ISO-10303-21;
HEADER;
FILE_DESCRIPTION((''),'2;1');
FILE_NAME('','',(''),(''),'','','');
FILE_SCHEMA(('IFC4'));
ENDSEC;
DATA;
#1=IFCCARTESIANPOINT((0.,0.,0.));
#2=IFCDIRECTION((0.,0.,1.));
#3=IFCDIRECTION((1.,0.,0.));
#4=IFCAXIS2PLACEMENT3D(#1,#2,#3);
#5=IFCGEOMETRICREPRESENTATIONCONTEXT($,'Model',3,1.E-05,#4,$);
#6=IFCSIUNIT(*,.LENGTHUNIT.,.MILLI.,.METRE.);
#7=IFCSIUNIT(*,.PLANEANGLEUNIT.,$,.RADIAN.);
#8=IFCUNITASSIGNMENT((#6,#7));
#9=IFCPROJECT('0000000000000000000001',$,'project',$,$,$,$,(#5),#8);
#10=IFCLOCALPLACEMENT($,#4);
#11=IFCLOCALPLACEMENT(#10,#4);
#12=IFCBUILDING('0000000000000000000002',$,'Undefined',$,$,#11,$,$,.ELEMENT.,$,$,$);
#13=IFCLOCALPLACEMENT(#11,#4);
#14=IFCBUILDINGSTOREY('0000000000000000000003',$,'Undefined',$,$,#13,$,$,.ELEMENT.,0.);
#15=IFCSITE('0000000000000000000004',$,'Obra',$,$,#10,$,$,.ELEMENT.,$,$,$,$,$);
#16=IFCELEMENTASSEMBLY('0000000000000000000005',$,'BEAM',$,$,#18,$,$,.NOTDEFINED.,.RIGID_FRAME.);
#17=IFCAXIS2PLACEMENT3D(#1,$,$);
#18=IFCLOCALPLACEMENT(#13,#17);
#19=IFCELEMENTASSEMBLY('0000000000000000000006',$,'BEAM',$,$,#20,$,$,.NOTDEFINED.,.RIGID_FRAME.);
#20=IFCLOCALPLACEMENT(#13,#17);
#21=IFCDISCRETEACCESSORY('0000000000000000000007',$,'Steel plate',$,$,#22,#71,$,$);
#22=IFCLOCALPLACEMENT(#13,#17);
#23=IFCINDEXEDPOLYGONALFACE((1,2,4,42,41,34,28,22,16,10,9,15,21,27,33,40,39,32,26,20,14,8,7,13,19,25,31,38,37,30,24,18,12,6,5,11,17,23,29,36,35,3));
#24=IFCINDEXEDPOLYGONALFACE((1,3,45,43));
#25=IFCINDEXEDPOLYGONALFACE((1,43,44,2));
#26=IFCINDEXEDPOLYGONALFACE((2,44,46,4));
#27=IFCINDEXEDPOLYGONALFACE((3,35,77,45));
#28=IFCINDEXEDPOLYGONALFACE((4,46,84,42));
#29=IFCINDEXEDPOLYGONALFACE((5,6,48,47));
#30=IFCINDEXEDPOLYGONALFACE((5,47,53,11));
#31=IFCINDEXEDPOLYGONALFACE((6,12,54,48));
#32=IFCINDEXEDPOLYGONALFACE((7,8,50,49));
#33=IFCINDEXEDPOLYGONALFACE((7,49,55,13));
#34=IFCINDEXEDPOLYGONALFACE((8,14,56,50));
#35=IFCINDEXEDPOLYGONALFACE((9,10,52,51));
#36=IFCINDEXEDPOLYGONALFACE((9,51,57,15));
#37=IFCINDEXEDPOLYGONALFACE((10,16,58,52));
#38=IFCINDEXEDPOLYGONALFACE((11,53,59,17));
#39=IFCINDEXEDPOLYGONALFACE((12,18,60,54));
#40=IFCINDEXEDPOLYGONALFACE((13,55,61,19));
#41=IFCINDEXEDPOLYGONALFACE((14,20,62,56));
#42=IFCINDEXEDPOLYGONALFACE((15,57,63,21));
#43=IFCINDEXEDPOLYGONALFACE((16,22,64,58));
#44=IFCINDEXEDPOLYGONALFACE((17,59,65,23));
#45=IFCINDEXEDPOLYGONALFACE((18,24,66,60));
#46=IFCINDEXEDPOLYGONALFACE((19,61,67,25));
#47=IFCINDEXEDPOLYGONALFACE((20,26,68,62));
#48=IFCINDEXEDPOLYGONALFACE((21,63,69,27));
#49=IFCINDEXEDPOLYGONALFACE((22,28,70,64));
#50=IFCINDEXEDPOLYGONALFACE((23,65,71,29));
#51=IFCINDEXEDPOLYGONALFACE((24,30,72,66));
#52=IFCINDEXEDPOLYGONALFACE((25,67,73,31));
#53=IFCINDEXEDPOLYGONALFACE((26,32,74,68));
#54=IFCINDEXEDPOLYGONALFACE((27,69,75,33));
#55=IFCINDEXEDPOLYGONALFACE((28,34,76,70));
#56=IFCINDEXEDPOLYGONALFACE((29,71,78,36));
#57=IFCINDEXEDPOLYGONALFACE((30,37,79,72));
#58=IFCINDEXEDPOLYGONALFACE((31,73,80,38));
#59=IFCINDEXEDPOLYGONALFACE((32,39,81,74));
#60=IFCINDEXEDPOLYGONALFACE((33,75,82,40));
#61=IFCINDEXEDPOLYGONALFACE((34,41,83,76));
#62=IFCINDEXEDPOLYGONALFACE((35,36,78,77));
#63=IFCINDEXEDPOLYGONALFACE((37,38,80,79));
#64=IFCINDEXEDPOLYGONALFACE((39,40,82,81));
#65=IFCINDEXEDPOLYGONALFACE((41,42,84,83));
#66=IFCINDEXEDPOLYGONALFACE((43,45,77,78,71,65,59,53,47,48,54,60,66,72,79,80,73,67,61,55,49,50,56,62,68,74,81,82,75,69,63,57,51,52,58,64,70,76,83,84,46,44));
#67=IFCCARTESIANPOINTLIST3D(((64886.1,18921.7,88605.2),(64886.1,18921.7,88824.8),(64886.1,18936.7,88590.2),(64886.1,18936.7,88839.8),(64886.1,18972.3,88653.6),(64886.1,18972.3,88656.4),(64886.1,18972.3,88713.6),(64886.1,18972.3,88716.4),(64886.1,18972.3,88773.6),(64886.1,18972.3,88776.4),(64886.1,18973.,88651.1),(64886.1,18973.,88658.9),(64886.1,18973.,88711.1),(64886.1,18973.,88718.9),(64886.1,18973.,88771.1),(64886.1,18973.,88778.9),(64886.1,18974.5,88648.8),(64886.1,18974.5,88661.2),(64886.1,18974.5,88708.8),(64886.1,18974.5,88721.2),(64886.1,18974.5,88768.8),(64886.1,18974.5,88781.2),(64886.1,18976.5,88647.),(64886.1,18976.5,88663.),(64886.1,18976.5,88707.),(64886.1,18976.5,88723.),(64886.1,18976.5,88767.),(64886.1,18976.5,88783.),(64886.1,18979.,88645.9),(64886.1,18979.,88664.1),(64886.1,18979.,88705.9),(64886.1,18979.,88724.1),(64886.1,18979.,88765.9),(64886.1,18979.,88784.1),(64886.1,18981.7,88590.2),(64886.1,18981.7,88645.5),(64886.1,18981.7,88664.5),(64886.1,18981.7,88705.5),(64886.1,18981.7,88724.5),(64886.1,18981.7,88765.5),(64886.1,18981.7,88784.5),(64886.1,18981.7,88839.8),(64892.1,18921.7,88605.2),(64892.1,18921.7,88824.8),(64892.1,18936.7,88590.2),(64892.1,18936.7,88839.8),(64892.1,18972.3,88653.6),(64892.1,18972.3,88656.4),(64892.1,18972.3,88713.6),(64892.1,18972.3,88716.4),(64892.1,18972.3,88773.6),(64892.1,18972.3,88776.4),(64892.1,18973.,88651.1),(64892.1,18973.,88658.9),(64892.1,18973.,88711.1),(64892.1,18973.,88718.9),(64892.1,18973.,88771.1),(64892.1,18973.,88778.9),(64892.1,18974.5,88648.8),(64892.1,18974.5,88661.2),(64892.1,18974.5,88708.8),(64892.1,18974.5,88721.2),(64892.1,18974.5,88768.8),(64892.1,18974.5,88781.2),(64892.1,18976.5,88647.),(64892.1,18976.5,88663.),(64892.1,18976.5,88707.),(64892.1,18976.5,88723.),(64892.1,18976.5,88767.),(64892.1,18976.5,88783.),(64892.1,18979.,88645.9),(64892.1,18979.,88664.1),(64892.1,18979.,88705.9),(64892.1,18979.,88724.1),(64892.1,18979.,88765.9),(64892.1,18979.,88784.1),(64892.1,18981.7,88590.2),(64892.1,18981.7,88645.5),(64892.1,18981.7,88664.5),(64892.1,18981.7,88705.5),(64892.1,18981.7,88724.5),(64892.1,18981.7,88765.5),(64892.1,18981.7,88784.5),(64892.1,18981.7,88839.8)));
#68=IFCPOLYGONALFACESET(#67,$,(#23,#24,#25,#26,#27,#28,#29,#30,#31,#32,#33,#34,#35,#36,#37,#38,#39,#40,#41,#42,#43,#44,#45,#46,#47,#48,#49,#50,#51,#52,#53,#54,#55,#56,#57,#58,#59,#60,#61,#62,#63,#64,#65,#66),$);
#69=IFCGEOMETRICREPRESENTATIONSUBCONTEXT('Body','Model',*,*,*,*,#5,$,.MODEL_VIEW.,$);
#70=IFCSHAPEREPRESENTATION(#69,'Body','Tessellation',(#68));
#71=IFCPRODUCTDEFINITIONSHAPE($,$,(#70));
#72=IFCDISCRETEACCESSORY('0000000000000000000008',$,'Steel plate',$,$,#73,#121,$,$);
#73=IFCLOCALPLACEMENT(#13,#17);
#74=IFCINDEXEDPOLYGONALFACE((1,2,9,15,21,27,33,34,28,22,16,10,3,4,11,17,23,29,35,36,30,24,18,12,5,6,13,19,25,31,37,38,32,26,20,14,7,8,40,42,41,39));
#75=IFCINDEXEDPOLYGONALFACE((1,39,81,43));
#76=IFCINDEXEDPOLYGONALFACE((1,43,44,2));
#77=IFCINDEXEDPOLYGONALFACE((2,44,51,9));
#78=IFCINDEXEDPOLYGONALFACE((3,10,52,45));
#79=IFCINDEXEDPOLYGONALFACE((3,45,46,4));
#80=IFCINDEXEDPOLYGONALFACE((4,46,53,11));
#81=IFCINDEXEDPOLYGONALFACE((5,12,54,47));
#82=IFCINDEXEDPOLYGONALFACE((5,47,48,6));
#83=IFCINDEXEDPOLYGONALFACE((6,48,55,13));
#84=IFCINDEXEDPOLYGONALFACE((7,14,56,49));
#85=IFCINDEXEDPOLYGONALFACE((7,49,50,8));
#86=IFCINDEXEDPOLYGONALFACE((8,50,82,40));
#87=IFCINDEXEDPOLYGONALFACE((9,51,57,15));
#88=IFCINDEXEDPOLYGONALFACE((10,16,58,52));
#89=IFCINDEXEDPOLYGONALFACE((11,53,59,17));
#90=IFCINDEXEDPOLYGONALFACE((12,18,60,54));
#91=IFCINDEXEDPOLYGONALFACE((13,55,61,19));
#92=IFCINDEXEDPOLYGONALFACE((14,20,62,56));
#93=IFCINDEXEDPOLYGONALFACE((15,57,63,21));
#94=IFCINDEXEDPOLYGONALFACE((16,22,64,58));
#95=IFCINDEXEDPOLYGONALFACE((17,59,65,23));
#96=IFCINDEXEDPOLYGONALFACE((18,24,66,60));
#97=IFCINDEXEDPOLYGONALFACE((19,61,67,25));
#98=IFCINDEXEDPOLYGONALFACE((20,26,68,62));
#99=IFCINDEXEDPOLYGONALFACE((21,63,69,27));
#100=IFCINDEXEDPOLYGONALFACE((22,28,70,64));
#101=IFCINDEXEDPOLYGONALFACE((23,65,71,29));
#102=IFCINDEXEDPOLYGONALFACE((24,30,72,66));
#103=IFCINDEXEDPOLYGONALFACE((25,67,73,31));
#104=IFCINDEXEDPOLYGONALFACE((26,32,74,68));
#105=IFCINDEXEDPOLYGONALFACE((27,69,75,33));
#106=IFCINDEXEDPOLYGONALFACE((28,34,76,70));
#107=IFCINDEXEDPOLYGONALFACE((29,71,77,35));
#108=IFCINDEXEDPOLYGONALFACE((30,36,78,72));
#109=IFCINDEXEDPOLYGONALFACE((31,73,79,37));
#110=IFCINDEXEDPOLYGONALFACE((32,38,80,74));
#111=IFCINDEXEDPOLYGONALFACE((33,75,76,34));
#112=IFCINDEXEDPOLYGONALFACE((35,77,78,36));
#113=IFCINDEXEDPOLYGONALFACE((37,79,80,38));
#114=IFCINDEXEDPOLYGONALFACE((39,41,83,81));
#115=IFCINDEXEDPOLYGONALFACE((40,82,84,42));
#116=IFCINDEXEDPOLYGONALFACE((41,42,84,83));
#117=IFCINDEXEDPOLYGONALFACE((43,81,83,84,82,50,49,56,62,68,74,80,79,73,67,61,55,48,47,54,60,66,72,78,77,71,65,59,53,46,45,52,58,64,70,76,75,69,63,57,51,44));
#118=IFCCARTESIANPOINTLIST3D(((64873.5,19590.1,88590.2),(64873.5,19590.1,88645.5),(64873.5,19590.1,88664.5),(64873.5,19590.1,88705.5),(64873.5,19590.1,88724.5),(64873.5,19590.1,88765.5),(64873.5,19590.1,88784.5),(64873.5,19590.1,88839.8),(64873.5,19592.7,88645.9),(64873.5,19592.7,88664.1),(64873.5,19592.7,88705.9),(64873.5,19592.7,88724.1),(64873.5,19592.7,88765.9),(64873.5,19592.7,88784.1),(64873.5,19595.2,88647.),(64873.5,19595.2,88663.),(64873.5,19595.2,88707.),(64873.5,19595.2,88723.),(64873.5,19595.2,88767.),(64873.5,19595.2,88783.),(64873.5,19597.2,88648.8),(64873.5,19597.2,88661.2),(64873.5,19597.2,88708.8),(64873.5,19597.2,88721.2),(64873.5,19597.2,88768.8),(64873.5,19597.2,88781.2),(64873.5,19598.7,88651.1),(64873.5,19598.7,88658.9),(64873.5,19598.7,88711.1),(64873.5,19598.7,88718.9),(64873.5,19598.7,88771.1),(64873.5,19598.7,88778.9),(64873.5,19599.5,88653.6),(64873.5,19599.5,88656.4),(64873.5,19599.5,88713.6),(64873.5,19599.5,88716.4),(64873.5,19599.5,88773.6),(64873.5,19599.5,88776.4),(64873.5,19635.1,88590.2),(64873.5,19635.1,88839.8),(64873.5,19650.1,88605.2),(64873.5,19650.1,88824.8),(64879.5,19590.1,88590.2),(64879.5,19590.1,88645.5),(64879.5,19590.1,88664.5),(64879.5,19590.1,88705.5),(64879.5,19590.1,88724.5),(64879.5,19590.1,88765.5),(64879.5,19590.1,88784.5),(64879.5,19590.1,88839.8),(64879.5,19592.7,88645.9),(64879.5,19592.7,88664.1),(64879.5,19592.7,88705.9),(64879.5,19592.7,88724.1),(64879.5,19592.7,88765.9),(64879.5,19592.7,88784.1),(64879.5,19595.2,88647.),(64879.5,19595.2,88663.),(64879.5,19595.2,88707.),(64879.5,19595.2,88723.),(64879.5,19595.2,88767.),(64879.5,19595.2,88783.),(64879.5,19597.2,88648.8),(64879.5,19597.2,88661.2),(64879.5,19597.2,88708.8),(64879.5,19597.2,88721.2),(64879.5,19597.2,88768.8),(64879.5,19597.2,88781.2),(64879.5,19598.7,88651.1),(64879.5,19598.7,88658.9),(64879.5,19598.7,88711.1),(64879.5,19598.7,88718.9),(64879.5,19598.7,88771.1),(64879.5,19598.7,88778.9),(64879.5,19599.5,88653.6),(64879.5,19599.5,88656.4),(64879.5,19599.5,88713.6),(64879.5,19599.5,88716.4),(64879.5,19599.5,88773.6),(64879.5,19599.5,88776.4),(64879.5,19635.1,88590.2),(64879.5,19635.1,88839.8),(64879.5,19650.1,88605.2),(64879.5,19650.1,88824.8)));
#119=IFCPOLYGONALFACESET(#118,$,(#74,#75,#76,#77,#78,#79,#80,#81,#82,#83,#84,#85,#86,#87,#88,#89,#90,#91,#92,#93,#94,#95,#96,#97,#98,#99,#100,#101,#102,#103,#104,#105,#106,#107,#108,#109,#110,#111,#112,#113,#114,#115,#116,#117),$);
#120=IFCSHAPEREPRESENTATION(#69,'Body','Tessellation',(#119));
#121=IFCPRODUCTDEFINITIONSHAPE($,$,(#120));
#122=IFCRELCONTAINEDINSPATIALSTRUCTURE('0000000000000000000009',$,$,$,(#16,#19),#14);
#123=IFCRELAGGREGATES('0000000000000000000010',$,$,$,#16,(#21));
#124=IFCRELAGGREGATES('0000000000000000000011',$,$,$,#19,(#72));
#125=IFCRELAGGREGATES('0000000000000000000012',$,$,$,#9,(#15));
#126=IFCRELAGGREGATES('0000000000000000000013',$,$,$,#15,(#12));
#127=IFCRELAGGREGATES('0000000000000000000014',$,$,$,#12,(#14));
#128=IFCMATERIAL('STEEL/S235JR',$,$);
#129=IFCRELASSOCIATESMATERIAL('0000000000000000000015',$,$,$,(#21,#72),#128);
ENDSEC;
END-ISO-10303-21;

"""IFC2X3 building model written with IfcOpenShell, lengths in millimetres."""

from ifc_helpers import new_model, si_unit, frame, origin_with_axes, origin_2d_with_axis, place, context, subcontext, project, spatial, polyline, circle, outline, extrude, source, transform, mapped, material, element, aggregate, save


model = new_model("IFC2X3")

# Units and contexts
model_context = context("Model", 3, precision=1e-05, world=origin_with_axes())
body_context = subcontext(model_context, "Body", "Model", "MODEL_VIEW")
ifc_project = project(units=[si_unit("LENGTHUNIT", "METRE", prefix="MILLI"), si_unit("PLANEANGLEUNIT", "RADIAN")], contexts=[model_context])

# Site, building, storey
site_placement = place(None, origin_with_axes())
site = spatial("IfcSite", under=ifc_project, at=site_placement, Name="Obra", CompositionType="ELEMENT")
building_placement = place(site_placement, origin_with_axes())
building = spatial("IfcBuilding", under=site, at=building_placement, Name="Undefined", CompositionType="ELEMENT")
storey_placement = place(building_placement, origin_with_axes())
storey = spatial("IfcBuildingStorey", under=building, at=storey_placement, Name="Undefined", CompositionType="ELEMENT", Elevation=0.0)

# Element assemblies
ifc_material = material(Name="STEEL/S235JR")
assembly_1_placement = place(storey_placement, origin_with_axes())
assembly_1 = element("IfcElementAssembly", 1, at=assembly_1_placement, inside=storey, Name="BEAM", AssemblyPlace="NOTDEFINED", PredefinedType="RIGID_FRAME")
assembly_2_placement = place(storey_placement, origin_with_axes())
assembly_2 = element("IfcElementAssembly", 2, at=assembly_2_placement, inside=storey, Name="BEAM", AssemblyPlace="NOTDEFINED", PredefinedType="RIGID_FRAME")

# Discrete accessories, openings
discrete_accessory_1_placement = place(assembly_1_placement, frame((64889.1, 18981.7, 88590.2), z_axis=(-1.0, -0.000002, 0.0), x_axis=(0.000002, -1.0, 0.0)))
discrete_accessory_1 = element("IfcDiscreteAccessory", 3, at=discrete_accessory_1_placement, material=ifc_material, Name="Steel plate", context=body_context, shape_type="SweptSolid", body=[
    extrude(outline(polyline([(0.0, 0.0), (45.0, 0.0), (60.0, 15.0), (60.0, 234.6), (45.0, 249.6), (0.0, 249.6), (0.0, 0.0)])), frame((0.0, 0.0, -3.0), z_axis=(0.0, 0.0, 1.0), x_axis=(1.0, 0.0, 0.0)), (0.0, 0.0, 1.0), 6.0),
])
shared_shape_1 = source(origin_with_axes(), body_context, "Body", "SweptSolid", [
    extrude(circle(Radius=9.5, at=origin_2d_with_axis()), frame((0.0, -9.4, 0.0), z_axis=(0.0, 1.0, 0.0), x_axis=(1.0, 0.0, 0.0)), (0.0, 0.0, 1.0), 6.2),
])
opening_1_placement = place(assembly_1_placement, frame((64882.8, 18931.7, 88850.0), z_axis=(-0.000002, 1.0, 0.0), x_axis=(0.0, 0.0, -1.0)))
element("IfcOpeningElement", 4, at=opening_1_placement, cuts=discrete_accessory_1, ObjectType="Opening", context=body_context, shape_type="MappedRepresentation", body=[
    mapped(shared_shape_1, transform((75.0, 0.0, 50.0))),
    mapped(shared_shape_1, transform((135.0, 0.0, 50.0))),
    mapped(shared_shape_1, transform((195.0, 0.0, 50.0))),
])
aggregate(assembly_1, [discrete_accessory_1])
discrete_accessory_2_placement = place(assembly_2_placement, frame((64876.5, 19590.1, 88590.2), z_axis=(1.0, 0.000001, 0.0), x_axis=(-0.000002, 1.0, 0.0)))
discrete_accessory_2 = element("IfcDiscreteAccessory", 5, at=discrete_accessory_2_placement, material=ifc_material, Name="Steel plate", context=body_context, shape_type="SweptSolid", body=[
    extrude(outline(polyline([(0.0, 0.0), (45.0, 0.0), (60.0, 15.0), (60.0, 234.6), (45.0, 249.6), (0.0, 249.6), (0.0, 0.0)])), frame((0.0, 0.0, -3.0), z_axis=(0.0, 0.0, 1.0), x_axis=(1.0, 0.0, 0.0)), (0.0, 0.0, 1.0), 6.0),
])
opening_2_placement = place(assembly_2_placement, frame((64882.8, 19640.1, 88850.0), z_axis=(0.000002, -1.0, 0.0), x_axis=(0.0, 0.0, -1.0)))
element("IfcOpeningElement", 6, at=opening_2_placement, cuts=discrete_accessory_2, ObjectType="Opening", context=body_context, shape_type="MappedRepresentation", body=[
    mapped(shared_shape_1, transform((75.0, 0.0, 50.0))),
    mapped(shared_shape_1, transform((135.0, 0.0, 50.0))),
    mapped(shared_shape_1, transform((195.0, 0.0, 50.0))),
])
aggregate(assembly_2, [discrete_accessory_2])

save(model, "model.ifc")
